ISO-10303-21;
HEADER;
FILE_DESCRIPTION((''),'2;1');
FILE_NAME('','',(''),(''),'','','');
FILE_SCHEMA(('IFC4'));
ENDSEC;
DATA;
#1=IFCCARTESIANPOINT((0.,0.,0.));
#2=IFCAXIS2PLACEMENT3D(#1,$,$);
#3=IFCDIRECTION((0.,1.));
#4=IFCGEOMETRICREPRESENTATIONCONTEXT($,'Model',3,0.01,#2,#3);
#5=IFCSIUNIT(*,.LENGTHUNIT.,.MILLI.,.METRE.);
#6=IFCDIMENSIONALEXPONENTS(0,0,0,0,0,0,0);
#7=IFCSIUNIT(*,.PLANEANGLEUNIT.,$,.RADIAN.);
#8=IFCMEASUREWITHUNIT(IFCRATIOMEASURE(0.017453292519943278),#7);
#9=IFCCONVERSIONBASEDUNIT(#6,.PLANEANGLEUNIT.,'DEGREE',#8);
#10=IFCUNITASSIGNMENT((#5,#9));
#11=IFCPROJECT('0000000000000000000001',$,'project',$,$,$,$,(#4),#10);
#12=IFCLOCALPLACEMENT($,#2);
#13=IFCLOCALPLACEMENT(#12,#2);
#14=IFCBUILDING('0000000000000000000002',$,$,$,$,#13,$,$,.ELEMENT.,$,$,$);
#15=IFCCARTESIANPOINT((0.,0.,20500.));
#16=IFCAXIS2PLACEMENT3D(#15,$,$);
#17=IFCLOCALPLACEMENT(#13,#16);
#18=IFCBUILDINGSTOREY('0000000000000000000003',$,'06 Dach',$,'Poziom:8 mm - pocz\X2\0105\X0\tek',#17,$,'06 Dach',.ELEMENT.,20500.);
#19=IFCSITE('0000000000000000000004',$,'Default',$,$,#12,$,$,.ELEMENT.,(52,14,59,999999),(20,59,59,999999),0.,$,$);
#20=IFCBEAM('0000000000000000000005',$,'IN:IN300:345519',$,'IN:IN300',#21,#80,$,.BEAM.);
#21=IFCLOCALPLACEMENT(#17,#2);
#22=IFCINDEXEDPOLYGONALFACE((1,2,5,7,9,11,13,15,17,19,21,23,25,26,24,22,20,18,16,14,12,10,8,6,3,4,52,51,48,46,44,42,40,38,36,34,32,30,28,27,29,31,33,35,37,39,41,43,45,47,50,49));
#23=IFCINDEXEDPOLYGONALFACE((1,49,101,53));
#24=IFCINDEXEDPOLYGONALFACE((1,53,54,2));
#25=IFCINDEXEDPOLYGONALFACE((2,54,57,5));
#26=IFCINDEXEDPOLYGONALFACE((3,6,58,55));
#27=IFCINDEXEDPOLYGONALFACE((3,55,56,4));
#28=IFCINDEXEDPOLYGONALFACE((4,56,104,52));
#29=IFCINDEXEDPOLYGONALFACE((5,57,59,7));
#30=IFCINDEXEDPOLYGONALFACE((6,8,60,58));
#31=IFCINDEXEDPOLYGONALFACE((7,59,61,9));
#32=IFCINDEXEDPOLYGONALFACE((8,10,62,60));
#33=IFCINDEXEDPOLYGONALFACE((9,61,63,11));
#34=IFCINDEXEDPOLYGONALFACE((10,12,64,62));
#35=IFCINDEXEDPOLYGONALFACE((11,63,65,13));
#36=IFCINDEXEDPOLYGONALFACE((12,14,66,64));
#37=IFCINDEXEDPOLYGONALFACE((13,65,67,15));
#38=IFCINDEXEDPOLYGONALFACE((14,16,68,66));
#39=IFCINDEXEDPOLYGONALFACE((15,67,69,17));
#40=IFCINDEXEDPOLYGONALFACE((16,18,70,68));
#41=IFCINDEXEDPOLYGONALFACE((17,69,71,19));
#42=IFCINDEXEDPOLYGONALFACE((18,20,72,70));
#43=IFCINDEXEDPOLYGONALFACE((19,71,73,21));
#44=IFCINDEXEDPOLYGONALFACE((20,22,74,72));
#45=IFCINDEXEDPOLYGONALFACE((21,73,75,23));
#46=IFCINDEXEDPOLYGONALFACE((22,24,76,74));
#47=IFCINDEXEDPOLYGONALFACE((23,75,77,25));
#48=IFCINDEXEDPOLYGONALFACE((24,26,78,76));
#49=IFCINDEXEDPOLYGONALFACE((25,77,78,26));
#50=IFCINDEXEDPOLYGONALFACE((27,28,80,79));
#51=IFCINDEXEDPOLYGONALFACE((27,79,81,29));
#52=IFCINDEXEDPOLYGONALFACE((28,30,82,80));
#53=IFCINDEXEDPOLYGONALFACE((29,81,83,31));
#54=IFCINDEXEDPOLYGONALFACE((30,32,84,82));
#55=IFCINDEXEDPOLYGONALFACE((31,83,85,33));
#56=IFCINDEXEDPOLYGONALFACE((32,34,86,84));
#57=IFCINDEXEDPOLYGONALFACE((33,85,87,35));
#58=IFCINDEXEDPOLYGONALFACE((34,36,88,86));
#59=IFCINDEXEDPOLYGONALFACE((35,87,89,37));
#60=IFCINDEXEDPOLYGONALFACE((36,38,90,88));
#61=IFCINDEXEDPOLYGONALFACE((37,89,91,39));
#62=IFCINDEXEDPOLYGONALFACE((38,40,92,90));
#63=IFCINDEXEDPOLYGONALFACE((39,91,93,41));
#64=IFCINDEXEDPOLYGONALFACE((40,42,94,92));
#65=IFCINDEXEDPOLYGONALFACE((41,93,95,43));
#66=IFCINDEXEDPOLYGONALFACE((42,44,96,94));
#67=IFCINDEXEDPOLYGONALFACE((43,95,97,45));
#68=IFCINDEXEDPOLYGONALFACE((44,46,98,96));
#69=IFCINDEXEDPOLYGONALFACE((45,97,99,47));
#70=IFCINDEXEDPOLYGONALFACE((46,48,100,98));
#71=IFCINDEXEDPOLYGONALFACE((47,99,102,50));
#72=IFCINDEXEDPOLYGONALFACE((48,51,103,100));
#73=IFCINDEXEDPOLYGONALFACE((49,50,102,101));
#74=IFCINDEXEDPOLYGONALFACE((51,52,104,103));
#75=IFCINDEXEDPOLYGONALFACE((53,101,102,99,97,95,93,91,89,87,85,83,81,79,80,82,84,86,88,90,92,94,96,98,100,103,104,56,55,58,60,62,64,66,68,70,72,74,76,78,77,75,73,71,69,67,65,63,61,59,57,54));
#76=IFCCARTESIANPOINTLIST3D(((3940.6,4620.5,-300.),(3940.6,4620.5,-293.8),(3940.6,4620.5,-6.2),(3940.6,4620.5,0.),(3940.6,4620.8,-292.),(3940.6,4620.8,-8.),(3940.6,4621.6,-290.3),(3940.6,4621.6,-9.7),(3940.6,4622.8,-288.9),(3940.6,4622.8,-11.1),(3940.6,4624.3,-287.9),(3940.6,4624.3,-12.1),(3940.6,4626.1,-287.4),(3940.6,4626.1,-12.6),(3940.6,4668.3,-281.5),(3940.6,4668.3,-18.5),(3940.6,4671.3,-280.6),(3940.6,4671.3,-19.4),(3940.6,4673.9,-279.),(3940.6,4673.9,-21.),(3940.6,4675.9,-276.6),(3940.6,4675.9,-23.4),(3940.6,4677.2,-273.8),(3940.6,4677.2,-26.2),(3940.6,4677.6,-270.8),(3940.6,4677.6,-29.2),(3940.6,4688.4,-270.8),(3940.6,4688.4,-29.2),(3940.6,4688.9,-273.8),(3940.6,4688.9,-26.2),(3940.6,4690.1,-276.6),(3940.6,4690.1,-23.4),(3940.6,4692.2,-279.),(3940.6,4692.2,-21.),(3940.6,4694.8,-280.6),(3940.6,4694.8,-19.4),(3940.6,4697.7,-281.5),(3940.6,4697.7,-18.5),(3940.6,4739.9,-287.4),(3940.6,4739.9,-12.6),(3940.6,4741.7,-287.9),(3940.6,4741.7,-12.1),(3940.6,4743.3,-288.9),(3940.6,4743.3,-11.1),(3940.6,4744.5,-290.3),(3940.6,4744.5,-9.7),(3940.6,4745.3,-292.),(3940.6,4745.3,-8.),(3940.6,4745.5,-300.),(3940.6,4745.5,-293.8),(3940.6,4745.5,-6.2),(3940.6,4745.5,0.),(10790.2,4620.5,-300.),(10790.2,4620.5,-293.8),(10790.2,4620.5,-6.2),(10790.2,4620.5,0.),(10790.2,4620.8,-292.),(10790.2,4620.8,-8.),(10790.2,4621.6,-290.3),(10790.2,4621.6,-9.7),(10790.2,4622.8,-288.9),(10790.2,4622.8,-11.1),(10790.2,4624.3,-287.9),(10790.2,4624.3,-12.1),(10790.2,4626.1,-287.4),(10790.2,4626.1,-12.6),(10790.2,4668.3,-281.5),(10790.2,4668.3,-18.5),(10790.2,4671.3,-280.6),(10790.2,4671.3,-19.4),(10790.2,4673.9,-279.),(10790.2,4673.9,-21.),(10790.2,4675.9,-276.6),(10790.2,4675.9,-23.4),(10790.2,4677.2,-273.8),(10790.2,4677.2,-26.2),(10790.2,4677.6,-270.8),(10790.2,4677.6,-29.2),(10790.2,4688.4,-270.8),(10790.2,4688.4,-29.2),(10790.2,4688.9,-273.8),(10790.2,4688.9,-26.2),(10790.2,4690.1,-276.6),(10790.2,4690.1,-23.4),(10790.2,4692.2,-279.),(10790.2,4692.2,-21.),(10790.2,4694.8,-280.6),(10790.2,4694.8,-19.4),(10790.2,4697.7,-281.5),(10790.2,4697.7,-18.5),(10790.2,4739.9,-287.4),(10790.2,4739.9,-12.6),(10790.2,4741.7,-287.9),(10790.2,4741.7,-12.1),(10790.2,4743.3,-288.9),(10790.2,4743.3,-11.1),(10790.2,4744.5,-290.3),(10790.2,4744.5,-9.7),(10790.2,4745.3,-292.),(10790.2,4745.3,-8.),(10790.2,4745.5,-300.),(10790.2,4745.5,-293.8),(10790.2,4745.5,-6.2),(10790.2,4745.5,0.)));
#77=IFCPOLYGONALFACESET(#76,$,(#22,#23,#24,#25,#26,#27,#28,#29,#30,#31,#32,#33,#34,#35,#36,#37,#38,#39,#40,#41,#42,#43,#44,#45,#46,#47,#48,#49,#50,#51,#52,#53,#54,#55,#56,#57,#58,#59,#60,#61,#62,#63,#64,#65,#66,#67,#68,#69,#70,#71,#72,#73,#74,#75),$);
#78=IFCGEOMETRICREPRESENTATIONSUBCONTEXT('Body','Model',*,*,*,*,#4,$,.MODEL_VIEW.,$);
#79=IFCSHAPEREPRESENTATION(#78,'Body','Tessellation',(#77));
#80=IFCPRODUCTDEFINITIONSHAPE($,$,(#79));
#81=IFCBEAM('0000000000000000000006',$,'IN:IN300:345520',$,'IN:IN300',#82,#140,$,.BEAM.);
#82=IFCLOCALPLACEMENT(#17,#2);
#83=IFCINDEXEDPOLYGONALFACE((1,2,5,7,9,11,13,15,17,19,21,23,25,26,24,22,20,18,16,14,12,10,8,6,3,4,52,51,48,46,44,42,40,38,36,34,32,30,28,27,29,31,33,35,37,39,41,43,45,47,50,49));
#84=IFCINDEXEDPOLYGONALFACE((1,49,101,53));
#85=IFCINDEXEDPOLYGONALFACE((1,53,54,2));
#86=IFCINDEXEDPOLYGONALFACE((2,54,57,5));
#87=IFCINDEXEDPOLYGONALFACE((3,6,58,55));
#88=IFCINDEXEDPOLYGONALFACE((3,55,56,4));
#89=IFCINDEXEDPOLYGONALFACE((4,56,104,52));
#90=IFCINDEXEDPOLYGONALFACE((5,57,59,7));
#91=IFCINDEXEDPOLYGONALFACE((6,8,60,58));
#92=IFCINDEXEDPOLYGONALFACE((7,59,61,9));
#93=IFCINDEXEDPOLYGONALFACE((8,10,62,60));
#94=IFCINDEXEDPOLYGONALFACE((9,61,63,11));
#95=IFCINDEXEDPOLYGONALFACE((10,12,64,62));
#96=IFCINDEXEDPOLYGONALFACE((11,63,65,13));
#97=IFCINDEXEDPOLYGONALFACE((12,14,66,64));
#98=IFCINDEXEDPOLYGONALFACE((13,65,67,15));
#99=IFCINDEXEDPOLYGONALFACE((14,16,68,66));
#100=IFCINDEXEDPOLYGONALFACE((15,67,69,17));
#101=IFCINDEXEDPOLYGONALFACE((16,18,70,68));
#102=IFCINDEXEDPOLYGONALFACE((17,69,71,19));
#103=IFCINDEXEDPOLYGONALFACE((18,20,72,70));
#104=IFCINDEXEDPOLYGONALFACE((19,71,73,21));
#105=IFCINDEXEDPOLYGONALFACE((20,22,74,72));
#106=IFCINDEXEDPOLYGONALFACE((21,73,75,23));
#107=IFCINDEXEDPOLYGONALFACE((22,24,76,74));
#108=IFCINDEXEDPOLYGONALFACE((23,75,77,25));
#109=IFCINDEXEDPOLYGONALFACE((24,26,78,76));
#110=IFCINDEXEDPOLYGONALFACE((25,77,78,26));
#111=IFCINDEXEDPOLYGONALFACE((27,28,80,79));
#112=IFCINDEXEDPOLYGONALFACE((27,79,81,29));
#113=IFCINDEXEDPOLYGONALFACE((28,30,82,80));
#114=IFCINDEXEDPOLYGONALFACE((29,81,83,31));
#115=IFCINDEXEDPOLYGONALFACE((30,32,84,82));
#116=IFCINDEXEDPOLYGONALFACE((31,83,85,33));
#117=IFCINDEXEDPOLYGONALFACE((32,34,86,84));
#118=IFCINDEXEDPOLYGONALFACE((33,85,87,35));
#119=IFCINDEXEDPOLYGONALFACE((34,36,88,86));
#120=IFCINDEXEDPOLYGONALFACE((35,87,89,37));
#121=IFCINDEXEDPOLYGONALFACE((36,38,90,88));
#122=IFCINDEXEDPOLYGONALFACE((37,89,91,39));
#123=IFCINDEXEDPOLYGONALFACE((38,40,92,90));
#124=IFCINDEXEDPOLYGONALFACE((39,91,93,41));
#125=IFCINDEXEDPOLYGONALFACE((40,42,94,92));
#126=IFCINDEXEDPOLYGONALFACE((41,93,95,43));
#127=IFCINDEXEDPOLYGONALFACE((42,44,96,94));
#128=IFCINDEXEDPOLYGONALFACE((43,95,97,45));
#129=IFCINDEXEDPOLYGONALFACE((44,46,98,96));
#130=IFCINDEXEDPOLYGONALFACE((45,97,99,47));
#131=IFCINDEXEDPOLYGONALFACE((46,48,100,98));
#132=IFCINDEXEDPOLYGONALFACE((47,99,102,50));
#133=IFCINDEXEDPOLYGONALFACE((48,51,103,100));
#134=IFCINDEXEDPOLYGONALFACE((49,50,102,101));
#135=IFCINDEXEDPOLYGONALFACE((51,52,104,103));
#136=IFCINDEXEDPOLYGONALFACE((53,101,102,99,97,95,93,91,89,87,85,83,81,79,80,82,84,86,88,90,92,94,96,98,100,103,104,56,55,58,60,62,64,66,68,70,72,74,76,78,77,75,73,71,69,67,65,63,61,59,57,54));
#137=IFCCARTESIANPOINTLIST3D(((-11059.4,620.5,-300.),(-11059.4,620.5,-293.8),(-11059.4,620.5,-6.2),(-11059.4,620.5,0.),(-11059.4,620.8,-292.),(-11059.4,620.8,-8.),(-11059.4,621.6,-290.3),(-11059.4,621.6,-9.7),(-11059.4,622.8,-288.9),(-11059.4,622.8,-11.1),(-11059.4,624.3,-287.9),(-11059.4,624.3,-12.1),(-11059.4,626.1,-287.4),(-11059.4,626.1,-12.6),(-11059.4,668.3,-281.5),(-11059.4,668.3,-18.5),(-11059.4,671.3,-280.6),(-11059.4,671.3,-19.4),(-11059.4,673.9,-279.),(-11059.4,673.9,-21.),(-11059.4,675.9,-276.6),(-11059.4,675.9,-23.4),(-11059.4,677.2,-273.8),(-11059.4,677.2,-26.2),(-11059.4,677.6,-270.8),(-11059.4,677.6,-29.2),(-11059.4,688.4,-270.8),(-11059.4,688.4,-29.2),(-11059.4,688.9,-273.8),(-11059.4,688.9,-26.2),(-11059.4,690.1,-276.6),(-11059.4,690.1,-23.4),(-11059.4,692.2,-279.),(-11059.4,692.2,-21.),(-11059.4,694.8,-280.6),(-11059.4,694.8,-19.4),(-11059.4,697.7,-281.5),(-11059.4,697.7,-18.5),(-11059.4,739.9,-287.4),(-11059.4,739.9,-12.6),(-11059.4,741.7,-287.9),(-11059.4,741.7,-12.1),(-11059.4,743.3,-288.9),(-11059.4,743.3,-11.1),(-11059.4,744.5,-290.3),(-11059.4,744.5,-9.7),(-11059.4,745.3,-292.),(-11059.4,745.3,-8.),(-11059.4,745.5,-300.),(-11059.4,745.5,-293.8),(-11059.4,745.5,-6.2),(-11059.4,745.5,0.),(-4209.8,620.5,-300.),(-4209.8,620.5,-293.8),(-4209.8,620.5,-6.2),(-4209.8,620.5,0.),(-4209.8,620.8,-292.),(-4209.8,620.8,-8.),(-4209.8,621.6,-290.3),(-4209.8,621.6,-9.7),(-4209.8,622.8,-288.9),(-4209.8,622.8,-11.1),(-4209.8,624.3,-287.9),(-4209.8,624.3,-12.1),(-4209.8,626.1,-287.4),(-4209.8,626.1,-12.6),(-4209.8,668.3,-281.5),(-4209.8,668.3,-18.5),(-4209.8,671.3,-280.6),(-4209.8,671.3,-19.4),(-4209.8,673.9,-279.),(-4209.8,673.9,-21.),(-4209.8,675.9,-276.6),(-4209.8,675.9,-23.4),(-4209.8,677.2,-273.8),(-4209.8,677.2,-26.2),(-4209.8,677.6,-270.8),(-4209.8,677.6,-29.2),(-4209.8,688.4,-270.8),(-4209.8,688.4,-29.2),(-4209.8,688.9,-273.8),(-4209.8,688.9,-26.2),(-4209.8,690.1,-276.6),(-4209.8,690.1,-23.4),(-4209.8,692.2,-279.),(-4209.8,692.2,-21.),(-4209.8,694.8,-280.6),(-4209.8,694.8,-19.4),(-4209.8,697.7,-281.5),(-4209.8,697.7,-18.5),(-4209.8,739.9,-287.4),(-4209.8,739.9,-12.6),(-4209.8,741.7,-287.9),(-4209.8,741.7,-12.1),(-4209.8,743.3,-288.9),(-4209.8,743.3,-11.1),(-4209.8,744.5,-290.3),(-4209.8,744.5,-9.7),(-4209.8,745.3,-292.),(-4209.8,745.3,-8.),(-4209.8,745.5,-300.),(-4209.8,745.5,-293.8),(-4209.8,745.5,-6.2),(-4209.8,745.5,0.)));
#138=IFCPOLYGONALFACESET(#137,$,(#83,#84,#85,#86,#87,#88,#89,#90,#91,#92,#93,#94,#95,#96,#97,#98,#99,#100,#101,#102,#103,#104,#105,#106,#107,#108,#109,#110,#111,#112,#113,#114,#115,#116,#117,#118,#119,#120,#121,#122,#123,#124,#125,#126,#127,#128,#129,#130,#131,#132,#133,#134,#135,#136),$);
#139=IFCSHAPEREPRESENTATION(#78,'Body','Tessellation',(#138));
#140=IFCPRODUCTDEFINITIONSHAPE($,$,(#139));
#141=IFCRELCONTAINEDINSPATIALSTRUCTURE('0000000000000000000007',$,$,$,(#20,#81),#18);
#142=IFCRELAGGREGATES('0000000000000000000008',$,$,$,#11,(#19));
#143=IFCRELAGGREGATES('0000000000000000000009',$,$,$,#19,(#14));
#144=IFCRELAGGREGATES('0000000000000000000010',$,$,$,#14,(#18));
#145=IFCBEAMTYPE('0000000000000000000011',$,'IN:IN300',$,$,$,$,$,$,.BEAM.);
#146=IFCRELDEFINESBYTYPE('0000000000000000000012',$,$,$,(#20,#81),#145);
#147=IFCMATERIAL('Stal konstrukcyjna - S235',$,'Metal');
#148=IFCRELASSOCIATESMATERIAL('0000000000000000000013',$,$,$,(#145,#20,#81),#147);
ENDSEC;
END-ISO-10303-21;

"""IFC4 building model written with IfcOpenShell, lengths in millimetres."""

from ifc_helpers import new_model, entity, si_unit, converted_unit, direction, frame, origin, place, context, subcontext, project, spatial, line, arc, indexed_curve, outline, extrude, source, transform, mapped, material, type_object, type_shapes, element, save


model = new_model("IFC4")

# Units and contexts
model_context = context("Model", 3, precision=0.01, world=origin(), true_north=direction((0.0, 1.0)))
body_context = subcontext(model_context, "Body", "Model", "MODEL_VIEW")
ifc_project = project(units=[si_unit("LENGTHUNIT", "METRE", prefix="MILLI"), converted_unit("PLANEANGLEUNIT", "DEGREE", entity("IfcRatioMeasure", 0.017453292519943278), si_unit("PLANEANGLEUNIT", "RADIAN"), dimensions=[0, 0, 0, 0, 0, 0, 0])], contexts=[model_context])

# Site, building, storey
site_placement = place(None, origin())
site = spatial("IfcSite", under=ifc_project, at=site_placement, Name="Default", CompositionType="ELEMENT", RefLatitude=(52, 14, 59, 999999), RefLongitude=(20, 59, 59, 999999), RefElevation=0.0)
building_placement = place(site_placement, origin())
building = spatial("IfcBuilding", under=site, at=building_placement, CompositionType="ELEMENT")
storey_placement = place(building_placement, frame((0.0, 0.0, 20500.0)))
storey = spatial("IfcBuildingStorey", under=building, at=storey_placement, Name="06 Dach", ObjectType="Poziom:8 mm - początek", LongName="06 Dach", CompositionType="ELEMENT", Elevation=20500.0)

# Beams
ifc_material = material(Name="Stal konstrukcyjna - S235", Category="Metal")
beam_type_1 = type_object("IfcBeamType", Name="IN:IN300", PredefinedType="BEAM", material=ifc_material)
shared_shape_1 = source(origin(), body_context, "Body", "SweptSolid", [
    extrude(outline(indexed_curve([(143.8, -62.5), (150.0, -62.5), (150.0, 62.5), (143.8, 62.5), (139.6, 60.9), (137.4, 56.9), (131.5, 14.7), (127.9, 8.1), (120.8, 5.4), (-120.8, 5.4), (-127.9, 8.1), (-131.5, 14.7), (-137.4, 56.9), (-139.6, 60.9), (-143.8, 62.5), (-150.0, 62.5), (-150.0, -62.5), (-143.8, -62.5), (-139.6, -60.9), (-137.4, -56.9), (-131.5, -14.7), (-127.9, -8.1), (-120.8, -5.4), (120.8, -5.4), (127.9, -8.1), (131.5, -14.7), (137.4, -56.9), (139.6, -60.9)], segments=[line(1, 2, 3, 4), arc(4, 5, 6), line(6, 7), arc(7, 8, 9), line(9, 10), arc(10, 11, 12), line(12, 13), arc(13, 14, 15), line(15, 16, 17, 18), arc(18, 19, 20), line(20, 21), arc(21, 22, 23), line(23, 24), arc(24, 25, 26), line(26, 27), arc(27, 28, 1)], self_intersect=False)), frame((-3424.8, 0.0, 0.0), z_axis=(1.0, 0.0, 0.0), x_axis=(0.0, 0.0, -1.0)), (0.0, 0.0, 1.0), 6849.6),
])
type_shapes(beam_type_1, [shared_shape_1])
for number, where, name in (
    (1, (7365.4, 4683.0, -150.0), "IN:IN300:345519"),
    (2, (-7634.6, 683.0, -150.0), "IN:IN300:345520"),
):
    element("IfcBeam", number, at=place(storey_placement, frame(where)), inside=storey, type_object=beam_type_1, material=ifc_material, Name=name, ObjectType="IN:IN300", PredefinedType="BEAM", context=body_context, shape_type="MappedRepresentation", body=[
        mapped(shared_shape_1, transform((0.0, 0.0, 0.0), scale=1.0)),
    ])

save(model, "model.ifc")
